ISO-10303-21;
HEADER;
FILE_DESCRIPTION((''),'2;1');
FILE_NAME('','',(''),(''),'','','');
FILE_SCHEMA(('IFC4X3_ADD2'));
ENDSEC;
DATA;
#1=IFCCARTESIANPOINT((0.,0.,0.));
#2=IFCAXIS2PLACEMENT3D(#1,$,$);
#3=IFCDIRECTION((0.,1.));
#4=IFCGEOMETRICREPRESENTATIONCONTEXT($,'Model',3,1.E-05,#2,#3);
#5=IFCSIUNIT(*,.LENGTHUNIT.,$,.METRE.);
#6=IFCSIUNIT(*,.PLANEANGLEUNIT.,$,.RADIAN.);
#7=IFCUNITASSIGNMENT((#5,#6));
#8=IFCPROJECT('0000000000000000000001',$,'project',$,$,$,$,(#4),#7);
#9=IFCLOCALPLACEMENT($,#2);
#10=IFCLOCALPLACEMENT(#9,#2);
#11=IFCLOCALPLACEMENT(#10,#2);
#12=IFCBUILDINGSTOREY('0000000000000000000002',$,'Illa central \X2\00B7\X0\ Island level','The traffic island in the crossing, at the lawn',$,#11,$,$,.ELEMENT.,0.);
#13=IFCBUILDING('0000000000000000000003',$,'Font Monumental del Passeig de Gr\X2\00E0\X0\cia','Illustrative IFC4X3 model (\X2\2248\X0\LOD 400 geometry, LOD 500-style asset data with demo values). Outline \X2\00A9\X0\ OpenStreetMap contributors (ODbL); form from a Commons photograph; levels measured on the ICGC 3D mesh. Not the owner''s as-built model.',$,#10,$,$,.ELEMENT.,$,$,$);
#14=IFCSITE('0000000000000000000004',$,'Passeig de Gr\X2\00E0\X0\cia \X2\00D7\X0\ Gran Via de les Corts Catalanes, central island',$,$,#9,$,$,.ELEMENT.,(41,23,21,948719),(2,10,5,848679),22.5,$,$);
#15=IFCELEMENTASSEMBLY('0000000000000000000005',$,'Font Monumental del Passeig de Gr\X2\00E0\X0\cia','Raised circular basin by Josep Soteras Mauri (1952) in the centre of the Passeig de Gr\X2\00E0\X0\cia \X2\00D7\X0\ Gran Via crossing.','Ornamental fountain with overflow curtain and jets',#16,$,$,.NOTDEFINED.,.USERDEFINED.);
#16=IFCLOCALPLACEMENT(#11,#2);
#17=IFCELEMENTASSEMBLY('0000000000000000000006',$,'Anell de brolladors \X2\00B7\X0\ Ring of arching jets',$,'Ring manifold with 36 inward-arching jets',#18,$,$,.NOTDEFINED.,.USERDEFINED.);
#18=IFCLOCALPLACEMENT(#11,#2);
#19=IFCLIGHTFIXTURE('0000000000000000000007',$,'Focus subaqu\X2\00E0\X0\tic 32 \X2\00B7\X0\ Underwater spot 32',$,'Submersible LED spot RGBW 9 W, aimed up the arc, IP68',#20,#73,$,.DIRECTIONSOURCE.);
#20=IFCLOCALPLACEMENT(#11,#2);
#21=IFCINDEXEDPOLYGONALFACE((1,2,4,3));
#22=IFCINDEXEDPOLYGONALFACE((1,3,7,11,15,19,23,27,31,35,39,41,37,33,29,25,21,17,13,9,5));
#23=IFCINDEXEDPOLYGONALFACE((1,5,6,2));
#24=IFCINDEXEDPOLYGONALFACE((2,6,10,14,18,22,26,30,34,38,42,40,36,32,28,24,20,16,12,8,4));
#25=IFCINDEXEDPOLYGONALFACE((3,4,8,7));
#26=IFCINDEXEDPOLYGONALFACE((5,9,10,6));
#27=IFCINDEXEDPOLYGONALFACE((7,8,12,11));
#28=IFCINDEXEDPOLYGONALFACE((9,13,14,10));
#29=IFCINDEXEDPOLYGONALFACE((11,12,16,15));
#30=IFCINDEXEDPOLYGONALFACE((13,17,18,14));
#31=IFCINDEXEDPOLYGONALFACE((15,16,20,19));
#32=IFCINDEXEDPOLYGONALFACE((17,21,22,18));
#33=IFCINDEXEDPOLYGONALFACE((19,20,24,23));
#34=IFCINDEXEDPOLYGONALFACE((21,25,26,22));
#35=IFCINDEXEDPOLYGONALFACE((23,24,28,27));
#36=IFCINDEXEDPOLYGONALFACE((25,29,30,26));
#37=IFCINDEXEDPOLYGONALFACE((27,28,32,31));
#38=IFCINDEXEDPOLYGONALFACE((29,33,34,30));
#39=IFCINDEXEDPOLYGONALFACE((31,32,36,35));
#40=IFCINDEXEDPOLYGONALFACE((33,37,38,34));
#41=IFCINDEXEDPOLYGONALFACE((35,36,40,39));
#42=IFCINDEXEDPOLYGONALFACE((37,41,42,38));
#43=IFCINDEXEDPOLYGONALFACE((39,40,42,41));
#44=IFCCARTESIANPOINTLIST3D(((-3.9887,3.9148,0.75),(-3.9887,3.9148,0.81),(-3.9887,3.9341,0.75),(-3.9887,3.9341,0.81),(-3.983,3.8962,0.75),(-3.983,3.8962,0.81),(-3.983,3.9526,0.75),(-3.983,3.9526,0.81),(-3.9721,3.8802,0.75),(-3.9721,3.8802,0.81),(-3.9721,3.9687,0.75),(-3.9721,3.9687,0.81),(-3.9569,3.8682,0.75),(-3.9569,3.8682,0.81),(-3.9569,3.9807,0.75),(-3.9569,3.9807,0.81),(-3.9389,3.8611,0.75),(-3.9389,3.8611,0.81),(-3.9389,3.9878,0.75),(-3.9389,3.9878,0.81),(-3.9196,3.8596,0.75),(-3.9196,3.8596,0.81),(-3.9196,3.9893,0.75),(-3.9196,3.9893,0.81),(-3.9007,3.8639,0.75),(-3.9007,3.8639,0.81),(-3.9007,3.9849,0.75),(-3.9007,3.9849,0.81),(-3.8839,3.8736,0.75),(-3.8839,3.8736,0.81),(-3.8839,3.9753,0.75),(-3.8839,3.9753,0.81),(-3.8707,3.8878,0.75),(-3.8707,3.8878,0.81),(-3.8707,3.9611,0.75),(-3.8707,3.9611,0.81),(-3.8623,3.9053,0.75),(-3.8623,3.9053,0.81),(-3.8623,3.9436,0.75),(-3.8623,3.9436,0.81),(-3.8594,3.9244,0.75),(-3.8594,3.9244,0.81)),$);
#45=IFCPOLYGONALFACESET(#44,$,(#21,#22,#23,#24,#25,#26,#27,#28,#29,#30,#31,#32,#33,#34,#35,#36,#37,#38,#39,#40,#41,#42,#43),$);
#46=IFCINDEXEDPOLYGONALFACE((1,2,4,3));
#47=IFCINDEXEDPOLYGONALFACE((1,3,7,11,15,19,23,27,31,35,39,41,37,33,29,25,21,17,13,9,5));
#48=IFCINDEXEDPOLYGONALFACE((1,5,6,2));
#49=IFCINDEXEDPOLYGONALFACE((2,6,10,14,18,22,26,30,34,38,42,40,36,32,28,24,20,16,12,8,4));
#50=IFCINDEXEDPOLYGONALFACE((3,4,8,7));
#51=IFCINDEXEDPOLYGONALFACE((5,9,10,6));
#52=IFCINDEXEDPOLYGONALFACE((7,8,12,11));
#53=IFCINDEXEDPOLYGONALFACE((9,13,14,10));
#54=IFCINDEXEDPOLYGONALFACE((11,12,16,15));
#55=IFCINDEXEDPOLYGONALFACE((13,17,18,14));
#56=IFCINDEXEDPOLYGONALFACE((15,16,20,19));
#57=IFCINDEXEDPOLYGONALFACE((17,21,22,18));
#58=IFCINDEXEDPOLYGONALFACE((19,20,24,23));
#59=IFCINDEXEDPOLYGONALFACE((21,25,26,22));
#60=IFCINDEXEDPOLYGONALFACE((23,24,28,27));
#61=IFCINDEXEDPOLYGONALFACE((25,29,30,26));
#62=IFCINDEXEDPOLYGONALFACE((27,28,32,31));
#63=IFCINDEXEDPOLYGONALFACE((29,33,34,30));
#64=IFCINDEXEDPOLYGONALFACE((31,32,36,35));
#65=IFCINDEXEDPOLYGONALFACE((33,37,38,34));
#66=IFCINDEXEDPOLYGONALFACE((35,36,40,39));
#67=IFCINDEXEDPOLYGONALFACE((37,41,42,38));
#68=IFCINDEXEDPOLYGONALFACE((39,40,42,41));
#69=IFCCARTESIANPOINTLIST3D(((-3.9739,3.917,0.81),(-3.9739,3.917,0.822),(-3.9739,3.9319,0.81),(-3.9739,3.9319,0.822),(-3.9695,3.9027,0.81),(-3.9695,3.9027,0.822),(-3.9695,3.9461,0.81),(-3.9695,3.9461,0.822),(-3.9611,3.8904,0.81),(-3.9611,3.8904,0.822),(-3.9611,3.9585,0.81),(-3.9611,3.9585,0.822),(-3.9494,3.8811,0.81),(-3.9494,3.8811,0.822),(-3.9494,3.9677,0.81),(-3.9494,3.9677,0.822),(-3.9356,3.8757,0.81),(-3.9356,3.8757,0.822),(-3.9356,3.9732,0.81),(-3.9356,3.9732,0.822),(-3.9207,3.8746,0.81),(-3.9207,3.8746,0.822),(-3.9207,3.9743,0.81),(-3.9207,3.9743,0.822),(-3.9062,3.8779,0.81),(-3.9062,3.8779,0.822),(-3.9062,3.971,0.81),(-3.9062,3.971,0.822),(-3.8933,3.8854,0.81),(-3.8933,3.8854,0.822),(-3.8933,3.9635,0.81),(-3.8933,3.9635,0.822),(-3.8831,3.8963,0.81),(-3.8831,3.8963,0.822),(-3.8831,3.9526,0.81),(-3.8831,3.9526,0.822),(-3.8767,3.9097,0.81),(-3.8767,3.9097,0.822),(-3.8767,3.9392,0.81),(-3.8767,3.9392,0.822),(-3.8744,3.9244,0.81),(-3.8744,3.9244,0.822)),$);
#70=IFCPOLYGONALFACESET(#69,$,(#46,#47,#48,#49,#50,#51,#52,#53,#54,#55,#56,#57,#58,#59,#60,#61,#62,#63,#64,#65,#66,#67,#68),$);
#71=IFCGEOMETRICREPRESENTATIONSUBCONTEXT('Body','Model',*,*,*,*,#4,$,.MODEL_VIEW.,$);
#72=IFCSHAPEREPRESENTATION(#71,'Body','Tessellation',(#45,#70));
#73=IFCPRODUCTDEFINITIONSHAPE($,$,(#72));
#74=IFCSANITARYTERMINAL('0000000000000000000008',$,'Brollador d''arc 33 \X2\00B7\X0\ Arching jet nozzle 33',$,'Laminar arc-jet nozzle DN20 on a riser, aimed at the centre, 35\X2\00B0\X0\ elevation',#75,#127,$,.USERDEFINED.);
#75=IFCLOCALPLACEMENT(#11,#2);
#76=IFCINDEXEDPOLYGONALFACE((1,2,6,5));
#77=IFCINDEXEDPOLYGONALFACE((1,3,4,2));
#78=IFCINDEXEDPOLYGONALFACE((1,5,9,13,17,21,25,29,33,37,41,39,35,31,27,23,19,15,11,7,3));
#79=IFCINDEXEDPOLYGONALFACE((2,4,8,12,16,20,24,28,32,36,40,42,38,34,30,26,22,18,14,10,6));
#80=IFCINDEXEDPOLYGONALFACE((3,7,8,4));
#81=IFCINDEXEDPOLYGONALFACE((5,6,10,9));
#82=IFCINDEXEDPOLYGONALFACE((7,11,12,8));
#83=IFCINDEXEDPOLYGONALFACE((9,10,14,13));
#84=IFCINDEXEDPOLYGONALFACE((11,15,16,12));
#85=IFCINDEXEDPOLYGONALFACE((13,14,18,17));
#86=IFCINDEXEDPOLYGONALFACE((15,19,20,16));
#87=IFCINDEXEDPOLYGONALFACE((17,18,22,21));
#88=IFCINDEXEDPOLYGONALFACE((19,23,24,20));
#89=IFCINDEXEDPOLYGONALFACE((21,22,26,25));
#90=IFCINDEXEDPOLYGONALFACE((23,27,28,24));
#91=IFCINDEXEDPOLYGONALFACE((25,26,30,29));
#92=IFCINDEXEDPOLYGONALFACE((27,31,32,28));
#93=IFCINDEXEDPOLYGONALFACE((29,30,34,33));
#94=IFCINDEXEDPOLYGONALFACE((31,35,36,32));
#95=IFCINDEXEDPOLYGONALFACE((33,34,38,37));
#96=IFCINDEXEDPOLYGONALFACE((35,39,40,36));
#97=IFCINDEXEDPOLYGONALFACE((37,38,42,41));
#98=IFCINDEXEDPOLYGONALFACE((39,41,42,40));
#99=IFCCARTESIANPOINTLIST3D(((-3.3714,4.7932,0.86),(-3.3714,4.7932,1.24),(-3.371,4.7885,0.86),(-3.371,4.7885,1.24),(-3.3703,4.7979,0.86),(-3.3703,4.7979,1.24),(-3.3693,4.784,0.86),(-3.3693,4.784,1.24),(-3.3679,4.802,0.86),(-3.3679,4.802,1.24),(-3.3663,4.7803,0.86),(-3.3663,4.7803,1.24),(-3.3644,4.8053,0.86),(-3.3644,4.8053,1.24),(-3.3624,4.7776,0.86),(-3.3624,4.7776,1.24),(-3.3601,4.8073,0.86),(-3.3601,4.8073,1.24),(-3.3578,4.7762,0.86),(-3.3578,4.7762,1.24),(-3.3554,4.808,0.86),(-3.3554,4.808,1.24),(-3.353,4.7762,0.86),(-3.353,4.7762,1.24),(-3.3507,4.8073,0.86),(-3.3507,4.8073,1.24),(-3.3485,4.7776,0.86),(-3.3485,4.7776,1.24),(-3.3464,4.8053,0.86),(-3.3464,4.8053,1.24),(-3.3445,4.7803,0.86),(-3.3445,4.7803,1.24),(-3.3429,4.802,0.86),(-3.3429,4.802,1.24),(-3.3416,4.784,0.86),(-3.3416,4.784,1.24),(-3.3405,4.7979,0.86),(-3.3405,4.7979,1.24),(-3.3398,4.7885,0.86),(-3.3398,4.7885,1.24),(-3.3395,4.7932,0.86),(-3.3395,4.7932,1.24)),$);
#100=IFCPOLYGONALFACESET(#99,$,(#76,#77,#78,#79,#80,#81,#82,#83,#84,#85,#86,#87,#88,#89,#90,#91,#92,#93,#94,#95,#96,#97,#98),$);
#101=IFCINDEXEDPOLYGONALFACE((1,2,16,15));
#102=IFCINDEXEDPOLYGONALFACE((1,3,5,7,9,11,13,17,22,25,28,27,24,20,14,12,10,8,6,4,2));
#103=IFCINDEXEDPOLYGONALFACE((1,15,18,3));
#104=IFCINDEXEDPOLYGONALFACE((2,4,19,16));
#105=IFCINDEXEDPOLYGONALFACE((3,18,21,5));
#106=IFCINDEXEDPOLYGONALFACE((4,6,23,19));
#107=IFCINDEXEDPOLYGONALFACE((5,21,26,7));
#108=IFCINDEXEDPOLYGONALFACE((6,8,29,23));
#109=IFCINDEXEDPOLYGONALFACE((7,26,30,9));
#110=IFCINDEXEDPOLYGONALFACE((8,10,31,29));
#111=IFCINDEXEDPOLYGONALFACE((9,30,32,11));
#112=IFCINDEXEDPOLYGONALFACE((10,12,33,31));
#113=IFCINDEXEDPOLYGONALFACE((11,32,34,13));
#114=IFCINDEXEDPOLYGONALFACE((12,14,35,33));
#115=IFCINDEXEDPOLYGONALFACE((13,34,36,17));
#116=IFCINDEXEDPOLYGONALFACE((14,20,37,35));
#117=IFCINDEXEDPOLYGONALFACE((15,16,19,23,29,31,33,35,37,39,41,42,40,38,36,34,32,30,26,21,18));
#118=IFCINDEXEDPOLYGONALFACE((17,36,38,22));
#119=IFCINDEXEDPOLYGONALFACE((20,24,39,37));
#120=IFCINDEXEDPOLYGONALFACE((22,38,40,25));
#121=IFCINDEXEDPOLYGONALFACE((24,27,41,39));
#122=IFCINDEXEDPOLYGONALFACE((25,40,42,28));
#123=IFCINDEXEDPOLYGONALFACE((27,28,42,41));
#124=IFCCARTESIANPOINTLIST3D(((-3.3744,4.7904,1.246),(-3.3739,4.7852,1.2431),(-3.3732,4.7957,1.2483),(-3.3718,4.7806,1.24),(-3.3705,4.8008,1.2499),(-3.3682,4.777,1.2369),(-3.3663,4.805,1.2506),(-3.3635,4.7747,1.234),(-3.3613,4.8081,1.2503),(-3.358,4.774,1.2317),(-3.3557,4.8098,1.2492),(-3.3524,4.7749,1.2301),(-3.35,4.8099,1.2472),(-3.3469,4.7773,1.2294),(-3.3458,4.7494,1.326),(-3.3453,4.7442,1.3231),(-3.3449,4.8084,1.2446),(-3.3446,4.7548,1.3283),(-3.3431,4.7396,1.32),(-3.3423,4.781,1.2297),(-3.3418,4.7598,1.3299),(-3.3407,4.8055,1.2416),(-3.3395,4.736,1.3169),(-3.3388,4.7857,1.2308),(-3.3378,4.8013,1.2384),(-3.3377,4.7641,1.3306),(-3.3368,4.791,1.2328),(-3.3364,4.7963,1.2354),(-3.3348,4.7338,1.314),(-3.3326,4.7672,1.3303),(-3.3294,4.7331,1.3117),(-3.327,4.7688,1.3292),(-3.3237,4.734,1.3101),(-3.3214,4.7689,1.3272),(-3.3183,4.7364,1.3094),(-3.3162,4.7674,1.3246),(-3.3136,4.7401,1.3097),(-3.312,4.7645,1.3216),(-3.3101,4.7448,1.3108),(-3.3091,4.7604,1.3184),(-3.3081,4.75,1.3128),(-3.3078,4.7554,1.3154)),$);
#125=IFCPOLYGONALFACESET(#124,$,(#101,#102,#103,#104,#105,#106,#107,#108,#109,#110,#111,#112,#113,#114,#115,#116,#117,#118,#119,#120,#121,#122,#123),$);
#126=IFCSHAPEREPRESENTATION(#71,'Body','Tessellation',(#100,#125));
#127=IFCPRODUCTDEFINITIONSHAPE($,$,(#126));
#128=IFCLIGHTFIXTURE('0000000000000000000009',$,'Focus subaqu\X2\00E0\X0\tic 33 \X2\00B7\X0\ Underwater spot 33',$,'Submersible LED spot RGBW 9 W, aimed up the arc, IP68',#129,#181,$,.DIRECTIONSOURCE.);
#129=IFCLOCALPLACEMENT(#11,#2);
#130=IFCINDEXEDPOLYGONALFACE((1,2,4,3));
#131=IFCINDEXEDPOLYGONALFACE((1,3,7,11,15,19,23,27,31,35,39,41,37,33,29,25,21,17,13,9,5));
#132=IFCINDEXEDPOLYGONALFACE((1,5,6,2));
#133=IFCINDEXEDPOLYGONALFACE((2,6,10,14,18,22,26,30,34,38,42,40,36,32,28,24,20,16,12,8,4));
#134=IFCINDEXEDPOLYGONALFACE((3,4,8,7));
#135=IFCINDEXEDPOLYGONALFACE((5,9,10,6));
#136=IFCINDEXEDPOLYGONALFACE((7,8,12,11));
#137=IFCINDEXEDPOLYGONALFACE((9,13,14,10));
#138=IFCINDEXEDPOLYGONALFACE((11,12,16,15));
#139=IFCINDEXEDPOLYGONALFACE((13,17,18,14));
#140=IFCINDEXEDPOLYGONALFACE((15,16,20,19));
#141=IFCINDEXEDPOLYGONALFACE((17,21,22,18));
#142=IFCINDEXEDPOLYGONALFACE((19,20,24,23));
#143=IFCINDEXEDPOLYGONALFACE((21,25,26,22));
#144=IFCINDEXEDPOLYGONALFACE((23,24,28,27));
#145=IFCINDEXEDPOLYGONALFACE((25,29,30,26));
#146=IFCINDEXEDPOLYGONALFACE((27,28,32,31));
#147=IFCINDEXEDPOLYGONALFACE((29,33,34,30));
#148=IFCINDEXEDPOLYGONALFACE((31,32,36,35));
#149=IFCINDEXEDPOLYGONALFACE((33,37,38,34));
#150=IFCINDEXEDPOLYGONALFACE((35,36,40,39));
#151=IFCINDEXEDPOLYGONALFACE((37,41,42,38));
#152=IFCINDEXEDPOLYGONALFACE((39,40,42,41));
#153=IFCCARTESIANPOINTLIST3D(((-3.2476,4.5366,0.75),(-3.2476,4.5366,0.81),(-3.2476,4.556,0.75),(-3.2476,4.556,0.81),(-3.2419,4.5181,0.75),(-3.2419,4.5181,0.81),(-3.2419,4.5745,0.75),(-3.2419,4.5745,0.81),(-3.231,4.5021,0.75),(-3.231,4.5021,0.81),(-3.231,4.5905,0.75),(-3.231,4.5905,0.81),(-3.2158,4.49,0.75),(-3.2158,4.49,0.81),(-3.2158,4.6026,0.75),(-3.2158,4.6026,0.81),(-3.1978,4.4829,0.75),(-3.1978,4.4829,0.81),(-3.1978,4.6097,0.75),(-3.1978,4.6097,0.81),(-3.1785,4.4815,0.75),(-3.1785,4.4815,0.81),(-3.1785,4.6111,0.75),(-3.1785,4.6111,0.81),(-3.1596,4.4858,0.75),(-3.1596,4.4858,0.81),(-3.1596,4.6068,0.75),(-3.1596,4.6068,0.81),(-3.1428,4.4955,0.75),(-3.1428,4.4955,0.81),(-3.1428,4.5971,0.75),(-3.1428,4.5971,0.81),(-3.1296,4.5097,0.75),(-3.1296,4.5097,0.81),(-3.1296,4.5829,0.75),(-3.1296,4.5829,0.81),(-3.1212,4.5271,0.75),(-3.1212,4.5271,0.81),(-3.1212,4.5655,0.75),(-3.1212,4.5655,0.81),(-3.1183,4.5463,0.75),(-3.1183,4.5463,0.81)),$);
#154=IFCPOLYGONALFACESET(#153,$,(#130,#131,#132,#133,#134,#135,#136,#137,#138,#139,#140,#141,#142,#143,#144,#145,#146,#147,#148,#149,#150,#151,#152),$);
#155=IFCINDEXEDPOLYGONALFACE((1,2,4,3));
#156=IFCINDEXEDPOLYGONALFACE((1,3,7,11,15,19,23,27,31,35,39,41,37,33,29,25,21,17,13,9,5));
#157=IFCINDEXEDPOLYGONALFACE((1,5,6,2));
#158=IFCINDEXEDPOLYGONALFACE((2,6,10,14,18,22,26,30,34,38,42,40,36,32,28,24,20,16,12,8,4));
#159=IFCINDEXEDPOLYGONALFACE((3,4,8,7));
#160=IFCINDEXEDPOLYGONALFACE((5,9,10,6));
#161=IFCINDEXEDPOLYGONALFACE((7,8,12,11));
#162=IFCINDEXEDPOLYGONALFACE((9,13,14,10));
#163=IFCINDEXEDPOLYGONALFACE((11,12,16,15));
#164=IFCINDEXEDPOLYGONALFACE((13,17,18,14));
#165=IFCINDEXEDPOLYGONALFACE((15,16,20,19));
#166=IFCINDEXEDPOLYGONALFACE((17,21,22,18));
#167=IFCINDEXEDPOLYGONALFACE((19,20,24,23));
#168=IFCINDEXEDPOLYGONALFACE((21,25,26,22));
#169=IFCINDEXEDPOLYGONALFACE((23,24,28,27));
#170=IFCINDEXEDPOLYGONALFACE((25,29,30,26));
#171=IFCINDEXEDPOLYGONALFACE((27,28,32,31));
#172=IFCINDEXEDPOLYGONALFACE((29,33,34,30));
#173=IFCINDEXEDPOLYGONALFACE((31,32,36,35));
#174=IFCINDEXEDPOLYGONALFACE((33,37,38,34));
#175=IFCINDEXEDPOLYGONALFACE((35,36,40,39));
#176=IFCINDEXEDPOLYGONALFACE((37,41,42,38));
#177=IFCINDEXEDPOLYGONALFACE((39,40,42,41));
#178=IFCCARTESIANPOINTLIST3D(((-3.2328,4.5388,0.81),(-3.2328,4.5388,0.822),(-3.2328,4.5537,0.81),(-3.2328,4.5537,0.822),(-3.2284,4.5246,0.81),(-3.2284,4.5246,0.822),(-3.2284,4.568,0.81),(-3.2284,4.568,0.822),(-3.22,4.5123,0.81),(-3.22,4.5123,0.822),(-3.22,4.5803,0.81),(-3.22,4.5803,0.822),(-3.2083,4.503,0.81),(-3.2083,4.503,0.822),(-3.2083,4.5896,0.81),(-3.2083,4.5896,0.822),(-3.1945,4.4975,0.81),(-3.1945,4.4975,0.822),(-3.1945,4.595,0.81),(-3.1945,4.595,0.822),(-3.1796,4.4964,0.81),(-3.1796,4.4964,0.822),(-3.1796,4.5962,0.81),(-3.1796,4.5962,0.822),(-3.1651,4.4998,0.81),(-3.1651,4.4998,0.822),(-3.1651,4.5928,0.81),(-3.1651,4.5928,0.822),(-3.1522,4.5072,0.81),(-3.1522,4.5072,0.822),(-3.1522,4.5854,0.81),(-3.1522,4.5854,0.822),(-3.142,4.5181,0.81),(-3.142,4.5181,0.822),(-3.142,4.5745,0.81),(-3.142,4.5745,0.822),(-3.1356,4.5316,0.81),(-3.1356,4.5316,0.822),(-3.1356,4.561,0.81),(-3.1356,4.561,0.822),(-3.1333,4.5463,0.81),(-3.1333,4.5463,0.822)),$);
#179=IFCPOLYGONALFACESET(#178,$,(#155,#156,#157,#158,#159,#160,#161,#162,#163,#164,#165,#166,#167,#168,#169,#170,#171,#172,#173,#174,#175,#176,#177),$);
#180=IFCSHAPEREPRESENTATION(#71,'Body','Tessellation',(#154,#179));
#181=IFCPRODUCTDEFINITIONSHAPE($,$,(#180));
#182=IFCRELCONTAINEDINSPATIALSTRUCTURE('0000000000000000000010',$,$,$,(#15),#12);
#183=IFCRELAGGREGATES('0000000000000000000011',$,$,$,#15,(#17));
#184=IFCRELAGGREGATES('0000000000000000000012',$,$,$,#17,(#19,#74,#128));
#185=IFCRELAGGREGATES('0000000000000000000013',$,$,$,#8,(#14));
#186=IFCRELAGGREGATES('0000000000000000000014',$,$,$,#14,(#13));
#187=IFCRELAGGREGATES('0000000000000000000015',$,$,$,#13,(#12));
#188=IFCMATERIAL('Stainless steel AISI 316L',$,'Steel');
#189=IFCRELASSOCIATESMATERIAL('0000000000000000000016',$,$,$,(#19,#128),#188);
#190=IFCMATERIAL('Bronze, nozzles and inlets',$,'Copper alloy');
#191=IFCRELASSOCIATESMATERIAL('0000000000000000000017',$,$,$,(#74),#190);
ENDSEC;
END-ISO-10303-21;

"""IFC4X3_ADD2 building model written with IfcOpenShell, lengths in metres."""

from ifc_helpers import new_model, si_unit, direction, frame, origin, origin_2d_with_axis, place, context, subcontext, project, spatial, circle, extrude, material, element, aggregate, save


model = new_model("IFC4X3_ADD2")

# Units and contexts
model_context = context("Model", 3, precision=1e-05, world=origin(), true_north=direction((0.0, 1.0)))
body_context = subcontext(model_context, "Body", "Model", "MODEL_VIEW")
ifc_project = project(units=[si_unit("LENGTHUNIT", "METRE"), si_unit("PLANEANGLEUNIT", "RADIAN")], contexts=[model_context])

# Site, building, storey
site_placement = place(None, origin())
site = spatial("IfcSite", under=ifc_project, at=site_placement, Name="Passeig de Gràcia × Gran Via de les Corts Catalanes, central island", CompositionType="ELEMENT", RefLatitude=(41, 23, 21, 948719), RefLongitude=(2, 10, 5, 848679), RefElevation=22.5)
building_placement = place(site_placement, origin())
building = spatial("IfcBuilding", under=site, at=building_placement, Name="Font Monumental del Passeig de Gràcia", Description="Illustrative IFC4X3 model (≈LOD 400 geometry, LOD 500-style asset data with demo values). Outline © OpenStreetMap contributors (ODbL); form from a Commons photograph; levels measured on the ICGC 3D mesh. Not the owner's as-built model.", CompositionType="ELEMENT")
storey_placement = place(building_placement, origin())
storey = spatial("IfcBuildingStorey", under=building, at=storey_placement, Name="Illa central · Island level", Description="The traffic island in the crossing, at the lawn", CompositionType="ELEMENT", Elevation=0.0)

# Element assemblies, light fixtures, sanitary terminal
assembly_1_placement = place(building_placement, origin())
assembly_1 = element("IfcElementAssembly", 1, at=assembly_1_placement, inside=storey, Name="Font Monumental del Passeig de Gràcia", Description="Raised circular basin by Josep Soteras Mauri (1952) in the centre of the Passeig de Gràcia × Gran Via crossing.", ObjectType="Ornamental fountain with overflow curtain and jets", AssemblyPlace="NOTDEFINED", PredefinedType="USERDEFINED")
assembly_2_placement = place(building_placement, origin())
assembly_2 = element("IfcElementAssembly", 2, at=assembly_2_placement, Name="Anell de brolladors · Ring of arching jets", ObjectType="Ring manifold with 36 inward-arching jets", AssemblyPlace="NOTDEFINED", PredefinedType="USERDEFINED")
ifc_material_1 = material(Name="Stainless steel AISI 316L", Category="Steel")
light_fixture_1_placement = place(building_placement, origin())
light_fixture_1 = element("IfcLightFixture", 3, at=light_fixture_1_placement, material=ifc_material_1, Name="Focus subaquàtic 32 · Underwater spot 32", ObjectType="Submersible LED spot RGBW 9 W, aimed up the arc, IP68", PredefinedType="DIRECTIONSOURCE", context=body_context, shape_type="SweptSolid", body=[
    extrude(circle(Radius=0.065, at=origin_2d_with_axis()), frame((-3.9244, 3.9244, 0.75)), (0.0, 0.0, 1.0), 0.06),
    extrude(circle(Radius=0.05, at=origin_2d_with_axis()), frame((-3.9244, 3.9244, 0.81)), (0.0, 0.0, 1.0), 0.012),
])
ifc_material_2 = material(Name="Bronze, nozzles and inlets", Category="Copper alloy")
sanitary_terminal_1_placement = place(building_placement, origin())
sanitary_terminal_1 = element("IfcSanitaryTerminal", 4, at=sanitary_terminal_1_placement, material=ifc_material_2, Name="Brollador d'arc 33 · Arching jet nozzle 33", ObjectType="Laminar arc-jet nozzle DN20 on a riser, aimed at the centre, 35° elevation", PredefinedType="USERDEFINED", context=body_context, shape_type="SweptSolid", body=[
    extrude(circle(Radius=0.016, at=origin_2d_with_axis()), frame((-3.3554, 4.792, 0.86), z_axis=(0.0, 0.0, 1.0), x_axis=(0.0, 1.0, 0.0)), (0.0, 0.0, 1.0), 0.38),
    extrude(circle(Radius=0.02, at=origin_2d_with_axis()), frame((-3.3554, 4.792, 1.24), z_axis=(0.303995, -0.43415, 0.847998), x_axis=(-0.819152, -0.573576, 0.0)), (0.0, 0.0, 1.0), 0.0943),
])
light_fixture_2_placement = place(building_placement, origin())
light_fixture_2 = element("IfcLightFixture", 5, at=light_fixture_2_placement, material=ifc_material_1, Name="Focus subaquàtic 33 · Underwater spot 33", ObjectType="Submersible LED spot RGBW 9 W, aimed up the arc, IP68", PredefinedType="DIRECTIONSOURCE", context=body_context, shape_type="SweptSolid", body=[
    extrude(circle(Radius=0.065, at=origin_2d_with_axis()), frame((-3.1833, 4.5463, 0.75)), (0.0, 0.0, 1.0), 0.06),
    extrude(circle(Radius=0.05, at=origin_2d_with_axis()), frame((-3.1833, 4.5463, 0.81)), (0.0, 0.0, 1.0), 0.012),
])
aggregate(assembly_1, [assembly_2])

aggregate(assembly_2, [light_fixture_1, sanitary_terminal_1, light_fixture_2])

save(model, "model.ifc")
